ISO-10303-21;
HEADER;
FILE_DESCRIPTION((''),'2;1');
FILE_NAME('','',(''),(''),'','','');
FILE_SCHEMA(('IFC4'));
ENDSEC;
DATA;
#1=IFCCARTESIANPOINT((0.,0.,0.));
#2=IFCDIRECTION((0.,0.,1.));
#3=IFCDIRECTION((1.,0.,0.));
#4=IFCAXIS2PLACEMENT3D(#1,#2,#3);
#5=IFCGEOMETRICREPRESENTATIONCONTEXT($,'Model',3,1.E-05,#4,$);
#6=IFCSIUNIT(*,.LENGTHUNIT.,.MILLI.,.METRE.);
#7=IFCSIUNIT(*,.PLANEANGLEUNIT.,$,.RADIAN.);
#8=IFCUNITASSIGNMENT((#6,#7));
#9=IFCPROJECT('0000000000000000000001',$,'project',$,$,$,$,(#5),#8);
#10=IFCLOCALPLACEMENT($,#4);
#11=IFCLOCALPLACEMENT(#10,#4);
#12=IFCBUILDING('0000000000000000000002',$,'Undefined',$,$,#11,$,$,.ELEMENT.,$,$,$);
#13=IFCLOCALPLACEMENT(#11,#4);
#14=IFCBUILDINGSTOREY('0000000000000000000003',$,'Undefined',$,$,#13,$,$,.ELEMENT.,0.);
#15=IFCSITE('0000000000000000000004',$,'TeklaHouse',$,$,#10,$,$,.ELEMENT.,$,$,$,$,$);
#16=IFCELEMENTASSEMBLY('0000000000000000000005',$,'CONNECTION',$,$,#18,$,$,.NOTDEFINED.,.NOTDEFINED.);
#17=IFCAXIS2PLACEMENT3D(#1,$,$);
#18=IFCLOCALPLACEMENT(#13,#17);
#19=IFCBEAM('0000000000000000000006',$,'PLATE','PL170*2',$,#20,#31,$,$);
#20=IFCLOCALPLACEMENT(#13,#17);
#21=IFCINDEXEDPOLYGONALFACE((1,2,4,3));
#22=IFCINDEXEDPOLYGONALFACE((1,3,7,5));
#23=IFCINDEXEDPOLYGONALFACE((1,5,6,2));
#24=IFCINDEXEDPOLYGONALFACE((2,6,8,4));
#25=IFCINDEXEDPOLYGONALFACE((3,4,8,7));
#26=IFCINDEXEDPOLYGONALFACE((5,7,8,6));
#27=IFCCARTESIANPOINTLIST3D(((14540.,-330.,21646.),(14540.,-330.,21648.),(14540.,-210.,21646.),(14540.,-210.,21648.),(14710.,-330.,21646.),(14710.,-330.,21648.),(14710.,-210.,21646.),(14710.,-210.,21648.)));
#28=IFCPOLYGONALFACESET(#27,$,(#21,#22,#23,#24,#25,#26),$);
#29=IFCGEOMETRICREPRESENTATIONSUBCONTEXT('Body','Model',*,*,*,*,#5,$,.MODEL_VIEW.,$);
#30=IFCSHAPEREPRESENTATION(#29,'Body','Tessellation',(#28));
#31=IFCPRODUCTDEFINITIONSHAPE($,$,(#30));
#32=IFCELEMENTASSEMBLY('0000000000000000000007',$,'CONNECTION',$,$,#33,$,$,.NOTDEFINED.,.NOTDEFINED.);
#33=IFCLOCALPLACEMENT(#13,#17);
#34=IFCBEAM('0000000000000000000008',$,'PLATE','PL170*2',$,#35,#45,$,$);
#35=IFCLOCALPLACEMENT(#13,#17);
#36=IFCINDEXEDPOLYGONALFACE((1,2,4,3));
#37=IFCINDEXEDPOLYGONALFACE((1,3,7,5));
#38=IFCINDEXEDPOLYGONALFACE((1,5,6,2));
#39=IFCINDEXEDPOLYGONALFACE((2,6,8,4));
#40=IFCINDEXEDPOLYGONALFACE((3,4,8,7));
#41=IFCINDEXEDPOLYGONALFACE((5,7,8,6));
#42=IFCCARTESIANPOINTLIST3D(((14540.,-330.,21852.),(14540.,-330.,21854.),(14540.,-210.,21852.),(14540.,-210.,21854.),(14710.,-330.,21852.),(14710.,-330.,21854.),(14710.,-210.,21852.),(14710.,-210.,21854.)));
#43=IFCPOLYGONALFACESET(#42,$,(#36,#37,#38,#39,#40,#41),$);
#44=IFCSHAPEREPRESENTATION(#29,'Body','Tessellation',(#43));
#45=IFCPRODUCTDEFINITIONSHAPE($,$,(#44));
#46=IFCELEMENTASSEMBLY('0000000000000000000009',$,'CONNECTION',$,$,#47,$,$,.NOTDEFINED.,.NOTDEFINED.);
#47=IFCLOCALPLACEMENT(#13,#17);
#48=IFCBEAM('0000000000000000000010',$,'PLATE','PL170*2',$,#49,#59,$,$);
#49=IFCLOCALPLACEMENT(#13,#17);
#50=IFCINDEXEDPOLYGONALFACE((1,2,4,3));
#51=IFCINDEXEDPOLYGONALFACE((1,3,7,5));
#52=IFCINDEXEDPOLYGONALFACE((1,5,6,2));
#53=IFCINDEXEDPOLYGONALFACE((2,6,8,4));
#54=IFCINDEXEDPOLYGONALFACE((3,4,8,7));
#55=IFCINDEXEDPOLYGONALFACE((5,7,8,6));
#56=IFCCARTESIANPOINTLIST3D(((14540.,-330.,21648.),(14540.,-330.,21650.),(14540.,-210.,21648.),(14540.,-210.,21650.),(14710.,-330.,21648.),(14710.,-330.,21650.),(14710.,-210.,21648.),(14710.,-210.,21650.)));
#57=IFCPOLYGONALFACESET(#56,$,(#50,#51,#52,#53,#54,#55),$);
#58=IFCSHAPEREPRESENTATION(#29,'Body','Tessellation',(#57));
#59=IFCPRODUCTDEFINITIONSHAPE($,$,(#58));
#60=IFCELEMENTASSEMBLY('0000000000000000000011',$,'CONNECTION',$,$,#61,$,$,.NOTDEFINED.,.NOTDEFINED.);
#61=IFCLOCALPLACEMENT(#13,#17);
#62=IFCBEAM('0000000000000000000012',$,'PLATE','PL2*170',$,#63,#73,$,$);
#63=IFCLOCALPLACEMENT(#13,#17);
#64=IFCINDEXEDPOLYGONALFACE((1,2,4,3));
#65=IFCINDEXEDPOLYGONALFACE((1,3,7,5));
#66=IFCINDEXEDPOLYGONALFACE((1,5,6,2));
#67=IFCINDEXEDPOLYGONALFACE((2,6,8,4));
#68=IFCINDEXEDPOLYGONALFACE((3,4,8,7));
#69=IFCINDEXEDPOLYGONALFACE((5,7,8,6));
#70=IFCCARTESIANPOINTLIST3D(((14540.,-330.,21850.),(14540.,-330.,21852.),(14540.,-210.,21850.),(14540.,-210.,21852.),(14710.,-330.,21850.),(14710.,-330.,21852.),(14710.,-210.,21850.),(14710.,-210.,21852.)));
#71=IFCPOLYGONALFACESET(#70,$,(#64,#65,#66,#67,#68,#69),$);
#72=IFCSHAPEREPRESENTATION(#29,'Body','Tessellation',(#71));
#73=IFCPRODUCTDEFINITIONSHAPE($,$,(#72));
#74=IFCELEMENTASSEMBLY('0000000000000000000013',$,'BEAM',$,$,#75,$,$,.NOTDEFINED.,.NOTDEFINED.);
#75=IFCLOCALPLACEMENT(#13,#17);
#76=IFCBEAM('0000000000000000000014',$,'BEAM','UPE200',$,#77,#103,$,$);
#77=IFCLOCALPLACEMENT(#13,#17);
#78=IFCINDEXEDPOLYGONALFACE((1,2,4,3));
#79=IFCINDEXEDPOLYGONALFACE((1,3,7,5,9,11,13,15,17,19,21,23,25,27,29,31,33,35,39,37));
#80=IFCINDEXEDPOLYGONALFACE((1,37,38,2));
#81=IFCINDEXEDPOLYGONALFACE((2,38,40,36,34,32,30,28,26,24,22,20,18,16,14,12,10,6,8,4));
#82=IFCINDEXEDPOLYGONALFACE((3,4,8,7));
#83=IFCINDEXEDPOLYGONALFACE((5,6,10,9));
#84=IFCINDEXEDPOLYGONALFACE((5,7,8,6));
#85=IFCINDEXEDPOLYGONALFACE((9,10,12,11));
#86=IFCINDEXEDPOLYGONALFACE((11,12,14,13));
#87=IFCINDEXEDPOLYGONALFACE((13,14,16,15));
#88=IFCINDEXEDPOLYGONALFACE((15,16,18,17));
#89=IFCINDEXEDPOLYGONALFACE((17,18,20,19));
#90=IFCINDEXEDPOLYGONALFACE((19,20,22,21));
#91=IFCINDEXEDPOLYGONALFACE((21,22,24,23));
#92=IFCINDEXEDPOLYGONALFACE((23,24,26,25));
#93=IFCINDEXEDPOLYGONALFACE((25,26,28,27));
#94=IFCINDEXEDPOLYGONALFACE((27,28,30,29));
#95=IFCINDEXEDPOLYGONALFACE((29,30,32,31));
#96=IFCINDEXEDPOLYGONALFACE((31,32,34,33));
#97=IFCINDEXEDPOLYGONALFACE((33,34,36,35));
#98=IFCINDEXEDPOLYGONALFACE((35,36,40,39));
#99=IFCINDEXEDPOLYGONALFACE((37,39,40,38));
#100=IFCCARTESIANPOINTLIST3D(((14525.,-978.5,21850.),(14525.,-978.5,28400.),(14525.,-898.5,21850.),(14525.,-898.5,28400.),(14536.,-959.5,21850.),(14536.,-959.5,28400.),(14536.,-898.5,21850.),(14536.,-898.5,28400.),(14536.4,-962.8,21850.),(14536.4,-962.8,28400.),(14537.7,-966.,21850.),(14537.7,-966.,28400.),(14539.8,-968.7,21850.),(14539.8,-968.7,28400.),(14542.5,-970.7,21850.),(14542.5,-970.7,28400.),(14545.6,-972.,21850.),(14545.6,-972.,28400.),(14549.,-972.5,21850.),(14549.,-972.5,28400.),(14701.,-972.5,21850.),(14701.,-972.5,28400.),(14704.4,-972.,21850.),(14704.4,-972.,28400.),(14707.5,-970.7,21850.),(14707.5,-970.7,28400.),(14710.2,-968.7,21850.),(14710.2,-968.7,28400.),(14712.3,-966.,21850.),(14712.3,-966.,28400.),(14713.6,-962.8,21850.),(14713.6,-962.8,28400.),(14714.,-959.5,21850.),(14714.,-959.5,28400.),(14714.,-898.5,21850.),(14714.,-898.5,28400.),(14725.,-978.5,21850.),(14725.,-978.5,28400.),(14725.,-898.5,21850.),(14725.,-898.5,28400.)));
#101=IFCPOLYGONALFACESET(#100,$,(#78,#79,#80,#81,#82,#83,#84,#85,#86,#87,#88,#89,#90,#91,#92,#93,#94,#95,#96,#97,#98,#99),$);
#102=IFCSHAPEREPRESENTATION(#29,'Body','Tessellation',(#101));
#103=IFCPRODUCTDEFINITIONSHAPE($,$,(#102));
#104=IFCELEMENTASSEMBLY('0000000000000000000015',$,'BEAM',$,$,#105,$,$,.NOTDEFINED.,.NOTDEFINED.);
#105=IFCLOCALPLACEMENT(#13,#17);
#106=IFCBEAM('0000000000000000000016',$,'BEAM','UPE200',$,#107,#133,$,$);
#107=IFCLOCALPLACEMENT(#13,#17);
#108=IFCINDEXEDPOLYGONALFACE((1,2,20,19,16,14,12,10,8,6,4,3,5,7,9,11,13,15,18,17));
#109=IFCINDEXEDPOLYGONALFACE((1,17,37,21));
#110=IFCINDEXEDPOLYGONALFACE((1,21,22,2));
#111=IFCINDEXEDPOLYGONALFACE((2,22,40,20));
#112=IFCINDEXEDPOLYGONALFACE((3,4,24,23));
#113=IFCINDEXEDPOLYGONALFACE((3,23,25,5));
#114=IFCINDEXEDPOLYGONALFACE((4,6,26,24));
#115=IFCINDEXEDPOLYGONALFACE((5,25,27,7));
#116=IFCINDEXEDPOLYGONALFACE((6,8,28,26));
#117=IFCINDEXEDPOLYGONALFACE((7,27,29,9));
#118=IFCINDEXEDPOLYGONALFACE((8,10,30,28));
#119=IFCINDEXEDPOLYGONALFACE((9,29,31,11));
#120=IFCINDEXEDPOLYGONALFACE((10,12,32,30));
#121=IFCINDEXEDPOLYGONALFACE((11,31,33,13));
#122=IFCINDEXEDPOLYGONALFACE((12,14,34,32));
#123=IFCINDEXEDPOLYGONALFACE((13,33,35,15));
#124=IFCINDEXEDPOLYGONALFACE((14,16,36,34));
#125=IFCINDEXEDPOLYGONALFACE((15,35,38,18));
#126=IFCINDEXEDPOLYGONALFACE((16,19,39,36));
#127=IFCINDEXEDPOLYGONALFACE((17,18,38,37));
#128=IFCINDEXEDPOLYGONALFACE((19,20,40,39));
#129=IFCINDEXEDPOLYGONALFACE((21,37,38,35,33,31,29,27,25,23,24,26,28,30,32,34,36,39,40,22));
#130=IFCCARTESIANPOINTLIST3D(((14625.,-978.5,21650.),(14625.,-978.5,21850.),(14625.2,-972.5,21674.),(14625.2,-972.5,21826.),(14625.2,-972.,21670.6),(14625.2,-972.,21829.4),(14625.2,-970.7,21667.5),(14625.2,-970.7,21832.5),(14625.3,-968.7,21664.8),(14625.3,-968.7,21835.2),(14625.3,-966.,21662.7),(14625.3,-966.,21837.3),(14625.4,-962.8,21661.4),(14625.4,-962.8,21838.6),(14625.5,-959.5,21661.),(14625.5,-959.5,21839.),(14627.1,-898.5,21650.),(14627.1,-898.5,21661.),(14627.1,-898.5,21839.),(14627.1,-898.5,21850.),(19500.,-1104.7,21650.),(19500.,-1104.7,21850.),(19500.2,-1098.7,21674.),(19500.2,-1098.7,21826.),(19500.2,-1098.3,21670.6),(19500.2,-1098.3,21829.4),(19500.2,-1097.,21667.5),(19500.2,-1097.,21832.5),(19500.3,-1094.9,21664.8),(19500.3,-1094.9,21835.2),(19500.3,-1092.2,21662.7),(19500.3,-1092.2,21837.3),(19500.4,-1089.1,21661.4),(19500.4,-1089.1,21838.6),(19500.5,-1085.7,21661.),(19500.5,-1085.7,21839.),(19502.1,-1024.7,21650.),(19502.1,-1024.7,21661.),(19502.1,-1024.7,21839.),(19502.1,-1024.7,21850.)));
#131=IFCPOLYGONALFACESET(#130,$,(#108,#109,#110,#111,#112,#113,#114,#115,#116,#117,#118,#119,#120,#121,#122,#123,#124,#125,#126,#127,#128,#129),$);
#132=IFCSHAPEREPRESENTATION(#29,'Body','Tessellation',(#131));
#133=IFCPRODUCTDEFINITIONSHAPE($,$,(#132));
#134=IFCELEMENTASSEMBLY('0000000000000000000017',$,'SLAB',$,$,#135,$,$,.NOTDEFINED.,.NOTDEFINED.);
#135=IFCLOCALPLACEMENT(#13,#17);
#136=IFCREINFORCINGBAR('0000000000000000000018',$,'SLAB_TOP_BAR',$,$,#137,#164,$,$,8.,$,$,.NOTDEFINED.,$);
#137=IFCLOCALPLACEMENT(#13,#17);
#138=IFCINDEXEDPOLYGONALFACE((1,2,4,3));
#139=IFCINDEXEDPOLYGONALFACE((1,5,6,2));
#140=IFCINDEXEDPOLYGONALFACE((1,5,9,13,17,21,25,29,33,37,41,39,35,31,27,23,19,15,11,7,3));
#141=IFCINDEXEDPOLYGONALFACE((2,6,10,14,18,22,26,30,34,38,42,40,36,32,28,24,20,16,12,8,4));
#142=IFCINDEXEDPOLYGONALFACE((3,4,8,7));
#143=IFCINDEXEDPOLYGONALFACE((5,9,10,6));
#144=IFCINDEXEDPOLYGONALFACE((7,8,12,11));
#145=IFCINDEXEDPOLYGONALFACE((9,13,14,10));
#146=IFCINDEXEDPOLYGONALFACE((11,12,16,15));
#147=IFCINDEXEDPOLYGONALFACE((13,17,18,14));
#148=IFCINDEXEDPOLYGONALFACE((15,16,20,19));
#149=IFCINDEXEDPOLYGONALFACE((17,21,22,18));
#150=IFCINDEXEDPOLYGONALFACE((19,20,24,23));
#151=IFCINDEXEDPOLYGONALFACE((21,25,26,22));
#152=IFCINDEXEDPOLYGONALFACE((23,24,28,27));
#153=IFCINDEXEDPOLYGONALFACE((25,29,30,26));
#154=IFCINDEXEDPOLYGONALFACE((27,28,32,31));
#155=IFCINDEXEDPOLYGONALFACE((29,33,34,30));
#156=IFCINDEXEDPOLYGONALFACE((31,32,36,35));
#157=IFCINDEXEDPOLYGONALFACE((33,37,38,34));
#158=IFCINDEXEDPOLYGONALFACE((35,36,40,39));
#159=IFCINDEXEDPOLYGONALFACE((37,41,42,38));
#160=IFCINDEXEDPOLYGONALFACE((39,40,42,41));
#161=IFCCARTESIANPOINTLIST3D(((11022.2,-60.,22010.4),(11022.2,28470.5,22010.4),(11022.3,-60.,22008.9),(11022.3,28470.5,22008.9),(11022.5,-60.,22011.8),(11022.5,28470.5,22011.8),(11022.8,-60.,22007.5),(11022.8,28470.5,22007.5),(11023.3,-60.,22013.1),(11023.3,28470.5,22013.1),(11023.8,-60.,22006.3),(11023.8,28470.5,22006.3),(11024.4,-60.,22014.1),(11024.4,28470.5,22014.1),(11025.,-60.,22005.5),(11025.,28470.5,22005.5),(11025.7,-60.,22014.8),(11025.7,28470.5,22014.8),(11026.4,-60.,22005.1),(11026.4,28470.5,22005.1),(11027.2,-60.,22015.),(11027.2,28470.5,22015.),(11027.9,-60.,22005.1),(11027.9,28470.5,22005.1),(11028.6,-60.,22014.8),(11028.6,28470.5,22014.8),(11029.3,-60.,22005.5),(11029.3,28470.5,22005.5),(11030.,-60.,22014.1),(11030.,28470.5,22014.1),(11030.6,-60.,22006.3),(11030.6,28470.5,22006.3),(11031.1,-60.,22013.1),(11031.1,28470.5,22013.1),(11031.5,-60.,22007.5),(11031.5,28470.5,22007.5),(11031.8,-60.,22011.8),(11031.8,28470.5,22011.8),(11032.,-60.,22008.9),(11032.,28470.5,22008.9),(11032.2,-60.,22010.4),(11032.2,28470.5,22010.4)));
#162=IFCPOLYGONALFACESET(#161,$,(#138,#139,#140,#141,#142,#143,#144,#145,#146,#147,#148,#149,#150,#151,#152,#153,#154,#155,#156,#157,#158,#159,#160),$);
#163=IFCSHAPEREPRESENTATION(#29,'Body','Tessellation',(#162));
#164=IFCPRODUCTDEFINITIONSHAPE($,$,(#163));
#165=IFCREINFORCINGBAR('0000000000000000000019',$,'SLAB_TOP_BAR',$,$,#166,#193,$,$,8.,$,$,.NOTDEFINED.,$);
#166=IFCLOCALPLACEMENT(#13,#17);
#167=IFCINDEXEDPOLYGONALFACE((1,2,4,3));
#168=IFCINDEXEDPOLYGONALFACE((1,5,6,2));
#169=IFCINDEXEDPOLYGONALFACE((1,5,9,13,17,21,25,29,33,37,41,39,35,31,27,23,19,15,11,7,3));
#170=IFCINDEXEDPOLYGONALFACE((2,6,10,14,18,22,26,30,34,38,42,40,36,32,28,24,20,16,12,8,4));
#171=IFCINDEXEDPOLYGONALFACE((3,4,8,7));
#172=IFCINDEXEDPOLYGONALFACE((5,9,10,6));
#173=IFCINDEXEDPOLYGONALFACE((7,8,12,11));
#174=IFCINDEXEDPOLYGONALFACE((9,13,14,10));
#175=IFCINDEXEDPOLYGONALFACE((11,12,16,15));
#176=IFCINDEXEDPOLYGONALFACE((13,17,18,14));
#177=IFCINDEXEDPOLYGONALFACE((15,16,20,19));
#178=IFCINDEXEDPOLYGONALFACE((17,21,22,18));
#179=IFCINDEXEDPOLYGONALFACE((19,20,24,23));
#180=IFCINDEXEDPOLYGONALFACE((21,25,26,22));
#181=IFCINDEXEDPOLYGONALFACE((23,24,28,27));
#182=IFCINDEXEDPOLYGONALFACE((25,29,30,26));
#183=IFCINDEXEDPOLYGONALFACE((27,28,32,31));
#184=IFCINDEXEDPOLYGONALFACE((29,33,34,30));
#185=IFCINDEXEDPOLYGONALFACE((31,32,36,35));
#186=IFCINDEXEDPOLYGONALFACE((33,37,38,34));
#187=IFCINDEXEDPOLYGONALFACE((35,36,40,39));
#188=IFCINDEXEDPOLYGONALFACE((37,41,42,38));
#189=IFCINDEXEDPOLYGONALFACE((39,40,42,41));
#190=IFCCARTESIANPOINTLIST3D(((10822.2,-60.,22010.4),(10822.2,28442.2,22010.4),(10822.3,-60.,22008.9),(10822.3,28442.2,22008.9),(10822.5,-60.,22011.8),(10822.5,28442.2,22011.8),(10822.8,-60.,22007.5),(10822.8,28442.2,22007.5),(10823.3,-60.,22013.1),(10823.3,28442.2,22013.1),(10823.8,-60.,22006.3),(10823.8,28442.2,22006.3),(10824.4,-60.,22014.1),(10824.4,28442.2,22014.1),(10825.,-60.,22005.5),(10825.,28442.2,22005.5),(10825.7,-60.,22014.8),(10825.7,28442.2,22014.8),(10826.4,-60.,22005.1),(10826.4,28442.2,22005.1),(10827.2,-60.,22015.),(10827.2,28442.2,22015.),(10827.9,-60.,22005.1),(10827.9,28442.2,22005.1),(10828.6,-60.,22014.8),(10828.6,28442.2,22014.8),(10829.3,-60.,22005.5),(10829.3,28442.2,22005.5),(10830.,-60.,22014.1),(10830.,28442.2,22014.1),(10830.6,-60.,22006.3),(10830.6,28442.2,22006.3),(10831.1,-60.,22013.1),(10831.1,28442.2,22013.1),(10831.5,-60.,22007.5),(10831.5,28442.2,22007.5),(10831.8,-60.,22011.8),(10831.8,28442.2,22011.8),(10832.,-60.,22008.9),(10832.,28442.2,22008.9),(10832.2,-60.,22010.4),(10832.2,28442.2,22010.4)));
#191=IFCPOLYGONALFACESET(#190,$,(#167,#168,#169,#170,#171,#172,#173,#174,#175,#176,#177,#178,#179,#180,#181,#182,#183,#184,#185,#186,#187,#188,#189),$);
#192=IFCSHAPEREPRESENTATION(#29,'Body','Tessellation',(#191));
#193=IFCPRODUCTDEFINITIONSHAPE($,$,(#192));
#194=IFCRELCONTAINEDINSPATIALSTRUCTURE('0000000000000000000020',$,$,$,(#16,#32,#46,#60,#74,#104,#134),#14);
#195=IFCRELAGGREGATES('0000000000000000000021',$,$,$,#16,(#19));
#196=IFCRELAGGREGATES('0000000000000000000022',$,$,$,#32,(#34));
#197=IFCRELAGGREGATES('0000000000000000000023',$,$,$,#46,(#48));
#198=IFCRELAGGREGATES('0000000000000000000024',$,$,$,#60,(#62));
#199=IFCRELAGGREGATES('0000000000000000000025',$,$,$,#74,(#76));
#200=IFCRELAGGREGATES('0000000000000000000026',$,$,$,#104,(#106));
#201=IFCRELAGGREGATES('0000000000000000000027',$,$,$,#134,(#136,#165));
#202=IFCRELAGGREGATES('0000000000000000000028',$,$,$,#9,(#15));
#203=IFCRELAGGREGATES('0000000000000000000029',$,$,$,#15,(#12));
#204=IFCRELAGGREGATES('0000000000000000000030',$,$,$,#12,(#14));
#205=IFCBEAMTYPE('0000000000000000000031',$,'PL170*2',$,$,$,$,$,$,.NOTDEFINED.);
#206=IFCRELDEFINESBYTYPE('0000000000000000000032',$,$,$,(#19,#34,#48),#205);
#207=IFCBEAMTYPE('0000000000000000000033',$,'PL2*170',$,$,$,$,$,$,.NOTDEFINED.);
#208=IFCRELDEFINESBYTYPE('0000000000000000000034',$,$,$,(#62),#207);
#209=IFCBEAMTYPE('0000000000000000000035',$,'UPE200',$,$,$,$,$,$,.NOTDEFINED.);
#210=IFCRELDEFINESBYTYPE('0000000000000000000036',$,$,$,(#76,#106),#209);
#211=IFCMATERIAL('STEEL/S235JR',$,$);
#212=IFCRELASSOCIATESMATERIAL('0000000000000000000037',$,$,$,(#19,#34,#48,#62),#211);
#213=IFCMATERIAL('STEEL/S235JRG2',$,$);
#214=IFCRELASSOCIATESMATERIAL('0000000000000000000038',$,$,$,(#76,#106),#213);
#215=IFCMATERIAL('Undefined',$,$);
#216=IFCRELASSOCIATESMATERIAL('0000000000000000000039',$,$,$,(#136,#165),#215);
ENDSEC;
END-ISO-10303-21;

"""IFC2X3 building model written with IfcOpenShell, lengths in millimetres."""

from ifc_helpers import new_model, entity, si_unit, frame, origin_with_axes, origin_2d_with_axis, place, context, subcontext, project, spatial, rectangle, u_section, extrude, source, transform, mapped, material, type_object, element, aggregate, save


model = new_model("IFC2X3")

# Units and contexts
model_context = context("Model", 3, precision=1e-05, world=origin_with_axes())
body_context = subcontext(model_context, "Body", "Model", "MODEL_VIEW")
ifc_project = project(units=[si_unit("LENGTHUNIT", "METRE", prefix="MILLI"), si_unit("PLANEANGLEUNIT", "RADIAN")], contexts=[model_context])

# Site, building, storey
site_placement = place(None, origin_with_axes())
site = spatial("IfcSite", under=ifc_project, at=site_placement, Name="TeklaHouse", CompositionType="ELEMENT")
building_placement = place(site_placement, origin_with_axes())
building = spatial("IfcBuilding", under=site, at=building_placement, Name="Undefined", CompositionType="ELEMENT")
storey_placement = place(building_placement, origin_with_axes())
storey = spatial("IfcBuildingStorey", under=building, at=storey_placement, Name="Undefined", CompositionType="ELEMENT", Elevation=0.0)

# Element assemblies, beams
assembly_1_placement = place(storey_placement, origin_with_axes())
assembly_1 = element("IfcElementAssembly", 1, at=assembly_1_placement, inside=storey, Name="CONNECTION", AssemblyPlace="NOTDEFINED", PredefinedType="NOTDEFINED")
ifc_material_1 = material(Name="STEEL/S235JR")
beam_type_1 = type_object("IfcBeamType", Name="PL170*2", PredefinedType="NOTDEFINED")
beam_1_placement = place(assembly_1_placement, frame((14625.0, -210.0, 21647.0), z_axis=(-1.0, 0.0, 0.0), x_axis=(0.0, -1.0, 0.0)))
beam_1 = element("IfcBeam", 2, at=beam_1_placement, type_object=beam_type_1, material=ifc_material_1, Name="PLATE", Description="PL170*2", context=body_context, shape_type="SweptSolid", body=[
    extrude(rectangle(XDim=2.0, YDim=170.0, at=origin_2d_with_axis()), frame((120.0, 0.0, 0.0), z_axis=(-1.0, 0.0, 0.0), x_axis=(0.0, -1.0, 0.0)), (0.0, 0.0, 1.0), 120.0),
])
aggregate(assembly_1, [beam_1])
assembly_2_placement = place(storey_placement, origin_with_axes())
assembly_2 = element("IfcElementAssembly", 3, at=assembly_2_placement, inside=storey, Name="CONNECTION", AssemblyPlace="NOTDEFINED", PredefinedType="NOTDEFINED")
beam_2_placement = place(assembly_2_placement, frame((14625.0, -210.0, 21853.0), z_axis=(-1.0, 0.0, 0.0), x_axis=(0.0, -1.0, 0.0)))
beam_2 = element("IfcBeam", 4, at=beam_2_placement, type_object=beam_type_1, material=ifc_material_1, Name="PLATE", Description="PL170*2", context=body_context, shape_type="SweptSolid", body=[
    extrude(rectangle(XDim=2.0, YDim=170.0, at=origin_2d_with_axis()), frame((120.0, 0.0, 0.0), z_axis=(-1.0, 0.0, 0.0), x_axis=(0.0, -1.0, 0.0)), (0.0, 0.0, 1.0), 120.0),
])
aggregate(assembly_2, [beam_2])
assembly_3_placement = place(storey_placement, origin_with_axes())
assembly_3 = element("IfcElementAssembly", 5, at=assembly_3_placement, inside=storey, Name="CONNECTION", AssemblyPlace="NOTDEFINED", PredefinedType="NOTDEFINED")
beam_3_placement = place(assembly_3_placement, frame((14625.0, -210.0, 21649.0), z_axis=(-1.0, 0.0, 0.0), x_axis=(0.0, -1.0, 0.0)))
beam_3 = element("IfcBeam", 6, at=beam_3_placement, type_object=beam_type_1, material=ifc_material_1, Name="PLATE", Description="PL170*2", context=body_context, shape_type="SweptSolid", body=[
    extrude(rectangle(XDim=2.0, YDim=170.0, at=origin_2d_with_axis()), frame((120.0, 0.0, 0.0), z_axis=(-1.0, 0.0, 0.0), x_axis=(0.0, -1.0, 0.0)), (0.0, 0.0, 1.0), 120.0),
])
aggregate(assembly_3, [beam_3])
assembly_4_placement = place(storey_placement, origin_with_axes())
assembly_4 = element("IfcElementAssembly", 7, at=assembly_4_placement, inside=storey, Name="CONNECTION", AssemblyPlace="NOTDEFINED", PredefinedType="NOTDEFINED")
beam_type_2 = type_object("IfcBeamType", Name="PL2*170", PredefinedType="NOTDEFINED")
beam_4_placement = place(assembly_4_placement, frame((14625.0, -210.0, 21851.0), z_axis=(-1.0, 0.0, 0.0), x_axis=(0.0, -1.0, 0.0)))
beam_4 = element("IfcBeam", 8, at=beam_4_placement, type_object=beam_type_2, material=ifc_material_1, Name="PLATE", Description="PL2*170", context=body_context, shape_type="SweptSolid", body=[
    extrude(rectangle(XDim=2.0, YDim=170.0, at=origin_2d_with_axis()), frame((120.0, 0.0, 0.0), z_axis=(-1.0, 0.0, 0.0), x_axis=(0.0, -1.0, 0.0)), (0.0, 0.0, 1.0), 120.0),
])
aggregate(assembly_4, [beam_4])
assembly_5_placement = place(storey_placement, origin_with_axes())
assembly_5 = element("IfcElementAssembly", 9, at=assembly_5_placement, inside=storey, Name="BEAM", AssemblyPlace="NOTDEFINED", PredefinedType="NOTDEFINED")
ifc_material_2 = material(Name="STEEL/S235JRG2")
beam_type_3 = type_object("IfcBeamType", Name="UPE200", PredefinedType="NOTDEFINED")
beam_5_placement = place(assembly_5_placement, frame((14625.0, -938.5, 21850.0), z_axis=(1.0, 0.0, 0.0), x_axis=(0.0, 0.0, 1.0)))
beam_5 = element("IfcBeam", 10, at=beam_5_placement, type_object=beam_type_3, material=ifc_material_2, Name="BEAM", Description="UPE200", context=body_context, shape_type="SweptSolid", body=[
    extrude(u_section(Depth=200.0, FlangeWidth=80.0, WebThickness=6.0, FlangeThickness=11.0, FilletRadius=13.0, at=origin_2d_with_axis()), frame((6550.0, 0.0, 0.0), z_axis=(-1.0, 0.0, 0.0), x_axis=(0.0, -1.0, 0.0)), (0.0, 0.0, 1.0), 6550.0),
])
aggregate(assembly_5, [beam_5])
assembly_6_placement = place(storey_placement, origin_with_axes())
assembly_6 = element("IfcElementAssembly", 11, at=assembly_6_placement, inside=storey, Name="BEAM", AssemblyPlace="NOTDEFINED", PredefinedType="NOTDEFINED")
beam_6_placement = place(assembly_6_placement, frame((14626.0, -938.5, 21750.0), z_axis=(0.0, 0.0, -1.0), x_axis=(0.999665, -0.025886, 0.0)))
beam_6 = element("IfcBeam", 12, at=beam_6_placement, type_object=beam_type_3, material=ifc_material_2, Name="BEAM", Description="UPE200", context=body_context, shape_type="SweptSolid", body=[
    extrude(u_section(Depth=200.0, FlangeWidth=80.0, WebThickness=6.0, FlangeThickness=11.0, FilletRadius=13.0, at=origin_2d_with_axis()), frame((4876.6, 0.0, 0.0), z_axis=(-1.0, 0.0, 0.0), x_axis=(0.0, -1.0, 0.0)), (0.0, 0.0, 1.0), 4876.6),
])
aggregate(assembly_6, [beam_6])

# Shared definitions
ifc_material_3 = material(Name="Undefined")

# Element assembly, reinforcing bars
assembly_7_placement = place(storey_placement, origin_with_axes())
assembly_7 = element("IfcElementAssembly", 13, at=assembly_7_placement, inside=storey, Name="SLAB", AssemblyPlace="NOTDEFINED", PredefinedType="NOTDEFINED")
shared_shape_1 = source(origin_with_axes(), body_context, "Body", "AdvancedSweptSolid", [
    entity("IfcSweptDiskSolid", entity("IfcTrimmedCurve", entity("IfcLine", entity("IfcCartesianPoint", [0.0, 0.0, 0.0]), entity("IfcVector", entity("IfcDirection", [1.0, 0.0, 0.0]), 1.0)), [entity("IfcParameterValue", 0.0)], [entity("IfcParameterValue", 28530.489588)], True, "PARAMETER"), 5.0, None, 0.0, 28530.5),
])
reinforcing_bar_1_placement = place(assembly_7_placement, frame((11027.2, -60.0, 22010.0), z_axis=(0.0, 0.0, 1.0), x_axis=(0.0, 1.0, 0.0)))
reinforcing_bar_1 = element("IfcReinforcingBar", 14, at=reinforcing_bar_1_placement, material=ifc_material_3, Name="SLAB_TOP_BAR", BarRole="NOTDEFINED", NominalDiameter=8.0, context=body_context, shape_type="MappedRepresentation", body=[
    mapped(shared_shape_1, transform((0.0, 0.0, 0.0))),
])
shared_shape_2 = source(origin_with_axes(), body_context, "Body", "AdvancedSweptSolid", [
    entity("IfcSweptDiskSolid", entity("IfcTrimmedCurve", entity("IfcLine", entity("IfcCartesianPoint", [0.0, 0.0, 0.0]), entity("IfcVector", entity("IfcDirection", [1.0, 0.0, 0.0]), 1.0)), [entity("IfcParameterValue", 0.0)], [entity("IfcParameterValue", 28502.247477)], True, "PARAMETER"), 5.0, None, 0.0, 28502.2),
])
reinforcing_bar_2_placement = place(assembly_7_placement, frame((10827.2, -60.0, 22010.0), z_axis=(0.0, 0.0, 1.0), x_axis=(0.0, 1.0, 0.0)))
reinforcing_bar_2 = element("IfcReinforcingBar", 15, at=reinforcing_bar_2_placement, material=ifc_material_3, Name="SLAB_TOP_BAR", BarRole="NOTDEFINED", NominalDiameter=8.0, context=body_context, shape_type="MappedRepresentation", body=[
    mapped(shared_shape_2, transform((0.0, 0.0, 0.0))),
])
aggregate(assembly_7, [reinforcing_bar_1, reinforcing_bar_2])

save(model, "model.ifc")
